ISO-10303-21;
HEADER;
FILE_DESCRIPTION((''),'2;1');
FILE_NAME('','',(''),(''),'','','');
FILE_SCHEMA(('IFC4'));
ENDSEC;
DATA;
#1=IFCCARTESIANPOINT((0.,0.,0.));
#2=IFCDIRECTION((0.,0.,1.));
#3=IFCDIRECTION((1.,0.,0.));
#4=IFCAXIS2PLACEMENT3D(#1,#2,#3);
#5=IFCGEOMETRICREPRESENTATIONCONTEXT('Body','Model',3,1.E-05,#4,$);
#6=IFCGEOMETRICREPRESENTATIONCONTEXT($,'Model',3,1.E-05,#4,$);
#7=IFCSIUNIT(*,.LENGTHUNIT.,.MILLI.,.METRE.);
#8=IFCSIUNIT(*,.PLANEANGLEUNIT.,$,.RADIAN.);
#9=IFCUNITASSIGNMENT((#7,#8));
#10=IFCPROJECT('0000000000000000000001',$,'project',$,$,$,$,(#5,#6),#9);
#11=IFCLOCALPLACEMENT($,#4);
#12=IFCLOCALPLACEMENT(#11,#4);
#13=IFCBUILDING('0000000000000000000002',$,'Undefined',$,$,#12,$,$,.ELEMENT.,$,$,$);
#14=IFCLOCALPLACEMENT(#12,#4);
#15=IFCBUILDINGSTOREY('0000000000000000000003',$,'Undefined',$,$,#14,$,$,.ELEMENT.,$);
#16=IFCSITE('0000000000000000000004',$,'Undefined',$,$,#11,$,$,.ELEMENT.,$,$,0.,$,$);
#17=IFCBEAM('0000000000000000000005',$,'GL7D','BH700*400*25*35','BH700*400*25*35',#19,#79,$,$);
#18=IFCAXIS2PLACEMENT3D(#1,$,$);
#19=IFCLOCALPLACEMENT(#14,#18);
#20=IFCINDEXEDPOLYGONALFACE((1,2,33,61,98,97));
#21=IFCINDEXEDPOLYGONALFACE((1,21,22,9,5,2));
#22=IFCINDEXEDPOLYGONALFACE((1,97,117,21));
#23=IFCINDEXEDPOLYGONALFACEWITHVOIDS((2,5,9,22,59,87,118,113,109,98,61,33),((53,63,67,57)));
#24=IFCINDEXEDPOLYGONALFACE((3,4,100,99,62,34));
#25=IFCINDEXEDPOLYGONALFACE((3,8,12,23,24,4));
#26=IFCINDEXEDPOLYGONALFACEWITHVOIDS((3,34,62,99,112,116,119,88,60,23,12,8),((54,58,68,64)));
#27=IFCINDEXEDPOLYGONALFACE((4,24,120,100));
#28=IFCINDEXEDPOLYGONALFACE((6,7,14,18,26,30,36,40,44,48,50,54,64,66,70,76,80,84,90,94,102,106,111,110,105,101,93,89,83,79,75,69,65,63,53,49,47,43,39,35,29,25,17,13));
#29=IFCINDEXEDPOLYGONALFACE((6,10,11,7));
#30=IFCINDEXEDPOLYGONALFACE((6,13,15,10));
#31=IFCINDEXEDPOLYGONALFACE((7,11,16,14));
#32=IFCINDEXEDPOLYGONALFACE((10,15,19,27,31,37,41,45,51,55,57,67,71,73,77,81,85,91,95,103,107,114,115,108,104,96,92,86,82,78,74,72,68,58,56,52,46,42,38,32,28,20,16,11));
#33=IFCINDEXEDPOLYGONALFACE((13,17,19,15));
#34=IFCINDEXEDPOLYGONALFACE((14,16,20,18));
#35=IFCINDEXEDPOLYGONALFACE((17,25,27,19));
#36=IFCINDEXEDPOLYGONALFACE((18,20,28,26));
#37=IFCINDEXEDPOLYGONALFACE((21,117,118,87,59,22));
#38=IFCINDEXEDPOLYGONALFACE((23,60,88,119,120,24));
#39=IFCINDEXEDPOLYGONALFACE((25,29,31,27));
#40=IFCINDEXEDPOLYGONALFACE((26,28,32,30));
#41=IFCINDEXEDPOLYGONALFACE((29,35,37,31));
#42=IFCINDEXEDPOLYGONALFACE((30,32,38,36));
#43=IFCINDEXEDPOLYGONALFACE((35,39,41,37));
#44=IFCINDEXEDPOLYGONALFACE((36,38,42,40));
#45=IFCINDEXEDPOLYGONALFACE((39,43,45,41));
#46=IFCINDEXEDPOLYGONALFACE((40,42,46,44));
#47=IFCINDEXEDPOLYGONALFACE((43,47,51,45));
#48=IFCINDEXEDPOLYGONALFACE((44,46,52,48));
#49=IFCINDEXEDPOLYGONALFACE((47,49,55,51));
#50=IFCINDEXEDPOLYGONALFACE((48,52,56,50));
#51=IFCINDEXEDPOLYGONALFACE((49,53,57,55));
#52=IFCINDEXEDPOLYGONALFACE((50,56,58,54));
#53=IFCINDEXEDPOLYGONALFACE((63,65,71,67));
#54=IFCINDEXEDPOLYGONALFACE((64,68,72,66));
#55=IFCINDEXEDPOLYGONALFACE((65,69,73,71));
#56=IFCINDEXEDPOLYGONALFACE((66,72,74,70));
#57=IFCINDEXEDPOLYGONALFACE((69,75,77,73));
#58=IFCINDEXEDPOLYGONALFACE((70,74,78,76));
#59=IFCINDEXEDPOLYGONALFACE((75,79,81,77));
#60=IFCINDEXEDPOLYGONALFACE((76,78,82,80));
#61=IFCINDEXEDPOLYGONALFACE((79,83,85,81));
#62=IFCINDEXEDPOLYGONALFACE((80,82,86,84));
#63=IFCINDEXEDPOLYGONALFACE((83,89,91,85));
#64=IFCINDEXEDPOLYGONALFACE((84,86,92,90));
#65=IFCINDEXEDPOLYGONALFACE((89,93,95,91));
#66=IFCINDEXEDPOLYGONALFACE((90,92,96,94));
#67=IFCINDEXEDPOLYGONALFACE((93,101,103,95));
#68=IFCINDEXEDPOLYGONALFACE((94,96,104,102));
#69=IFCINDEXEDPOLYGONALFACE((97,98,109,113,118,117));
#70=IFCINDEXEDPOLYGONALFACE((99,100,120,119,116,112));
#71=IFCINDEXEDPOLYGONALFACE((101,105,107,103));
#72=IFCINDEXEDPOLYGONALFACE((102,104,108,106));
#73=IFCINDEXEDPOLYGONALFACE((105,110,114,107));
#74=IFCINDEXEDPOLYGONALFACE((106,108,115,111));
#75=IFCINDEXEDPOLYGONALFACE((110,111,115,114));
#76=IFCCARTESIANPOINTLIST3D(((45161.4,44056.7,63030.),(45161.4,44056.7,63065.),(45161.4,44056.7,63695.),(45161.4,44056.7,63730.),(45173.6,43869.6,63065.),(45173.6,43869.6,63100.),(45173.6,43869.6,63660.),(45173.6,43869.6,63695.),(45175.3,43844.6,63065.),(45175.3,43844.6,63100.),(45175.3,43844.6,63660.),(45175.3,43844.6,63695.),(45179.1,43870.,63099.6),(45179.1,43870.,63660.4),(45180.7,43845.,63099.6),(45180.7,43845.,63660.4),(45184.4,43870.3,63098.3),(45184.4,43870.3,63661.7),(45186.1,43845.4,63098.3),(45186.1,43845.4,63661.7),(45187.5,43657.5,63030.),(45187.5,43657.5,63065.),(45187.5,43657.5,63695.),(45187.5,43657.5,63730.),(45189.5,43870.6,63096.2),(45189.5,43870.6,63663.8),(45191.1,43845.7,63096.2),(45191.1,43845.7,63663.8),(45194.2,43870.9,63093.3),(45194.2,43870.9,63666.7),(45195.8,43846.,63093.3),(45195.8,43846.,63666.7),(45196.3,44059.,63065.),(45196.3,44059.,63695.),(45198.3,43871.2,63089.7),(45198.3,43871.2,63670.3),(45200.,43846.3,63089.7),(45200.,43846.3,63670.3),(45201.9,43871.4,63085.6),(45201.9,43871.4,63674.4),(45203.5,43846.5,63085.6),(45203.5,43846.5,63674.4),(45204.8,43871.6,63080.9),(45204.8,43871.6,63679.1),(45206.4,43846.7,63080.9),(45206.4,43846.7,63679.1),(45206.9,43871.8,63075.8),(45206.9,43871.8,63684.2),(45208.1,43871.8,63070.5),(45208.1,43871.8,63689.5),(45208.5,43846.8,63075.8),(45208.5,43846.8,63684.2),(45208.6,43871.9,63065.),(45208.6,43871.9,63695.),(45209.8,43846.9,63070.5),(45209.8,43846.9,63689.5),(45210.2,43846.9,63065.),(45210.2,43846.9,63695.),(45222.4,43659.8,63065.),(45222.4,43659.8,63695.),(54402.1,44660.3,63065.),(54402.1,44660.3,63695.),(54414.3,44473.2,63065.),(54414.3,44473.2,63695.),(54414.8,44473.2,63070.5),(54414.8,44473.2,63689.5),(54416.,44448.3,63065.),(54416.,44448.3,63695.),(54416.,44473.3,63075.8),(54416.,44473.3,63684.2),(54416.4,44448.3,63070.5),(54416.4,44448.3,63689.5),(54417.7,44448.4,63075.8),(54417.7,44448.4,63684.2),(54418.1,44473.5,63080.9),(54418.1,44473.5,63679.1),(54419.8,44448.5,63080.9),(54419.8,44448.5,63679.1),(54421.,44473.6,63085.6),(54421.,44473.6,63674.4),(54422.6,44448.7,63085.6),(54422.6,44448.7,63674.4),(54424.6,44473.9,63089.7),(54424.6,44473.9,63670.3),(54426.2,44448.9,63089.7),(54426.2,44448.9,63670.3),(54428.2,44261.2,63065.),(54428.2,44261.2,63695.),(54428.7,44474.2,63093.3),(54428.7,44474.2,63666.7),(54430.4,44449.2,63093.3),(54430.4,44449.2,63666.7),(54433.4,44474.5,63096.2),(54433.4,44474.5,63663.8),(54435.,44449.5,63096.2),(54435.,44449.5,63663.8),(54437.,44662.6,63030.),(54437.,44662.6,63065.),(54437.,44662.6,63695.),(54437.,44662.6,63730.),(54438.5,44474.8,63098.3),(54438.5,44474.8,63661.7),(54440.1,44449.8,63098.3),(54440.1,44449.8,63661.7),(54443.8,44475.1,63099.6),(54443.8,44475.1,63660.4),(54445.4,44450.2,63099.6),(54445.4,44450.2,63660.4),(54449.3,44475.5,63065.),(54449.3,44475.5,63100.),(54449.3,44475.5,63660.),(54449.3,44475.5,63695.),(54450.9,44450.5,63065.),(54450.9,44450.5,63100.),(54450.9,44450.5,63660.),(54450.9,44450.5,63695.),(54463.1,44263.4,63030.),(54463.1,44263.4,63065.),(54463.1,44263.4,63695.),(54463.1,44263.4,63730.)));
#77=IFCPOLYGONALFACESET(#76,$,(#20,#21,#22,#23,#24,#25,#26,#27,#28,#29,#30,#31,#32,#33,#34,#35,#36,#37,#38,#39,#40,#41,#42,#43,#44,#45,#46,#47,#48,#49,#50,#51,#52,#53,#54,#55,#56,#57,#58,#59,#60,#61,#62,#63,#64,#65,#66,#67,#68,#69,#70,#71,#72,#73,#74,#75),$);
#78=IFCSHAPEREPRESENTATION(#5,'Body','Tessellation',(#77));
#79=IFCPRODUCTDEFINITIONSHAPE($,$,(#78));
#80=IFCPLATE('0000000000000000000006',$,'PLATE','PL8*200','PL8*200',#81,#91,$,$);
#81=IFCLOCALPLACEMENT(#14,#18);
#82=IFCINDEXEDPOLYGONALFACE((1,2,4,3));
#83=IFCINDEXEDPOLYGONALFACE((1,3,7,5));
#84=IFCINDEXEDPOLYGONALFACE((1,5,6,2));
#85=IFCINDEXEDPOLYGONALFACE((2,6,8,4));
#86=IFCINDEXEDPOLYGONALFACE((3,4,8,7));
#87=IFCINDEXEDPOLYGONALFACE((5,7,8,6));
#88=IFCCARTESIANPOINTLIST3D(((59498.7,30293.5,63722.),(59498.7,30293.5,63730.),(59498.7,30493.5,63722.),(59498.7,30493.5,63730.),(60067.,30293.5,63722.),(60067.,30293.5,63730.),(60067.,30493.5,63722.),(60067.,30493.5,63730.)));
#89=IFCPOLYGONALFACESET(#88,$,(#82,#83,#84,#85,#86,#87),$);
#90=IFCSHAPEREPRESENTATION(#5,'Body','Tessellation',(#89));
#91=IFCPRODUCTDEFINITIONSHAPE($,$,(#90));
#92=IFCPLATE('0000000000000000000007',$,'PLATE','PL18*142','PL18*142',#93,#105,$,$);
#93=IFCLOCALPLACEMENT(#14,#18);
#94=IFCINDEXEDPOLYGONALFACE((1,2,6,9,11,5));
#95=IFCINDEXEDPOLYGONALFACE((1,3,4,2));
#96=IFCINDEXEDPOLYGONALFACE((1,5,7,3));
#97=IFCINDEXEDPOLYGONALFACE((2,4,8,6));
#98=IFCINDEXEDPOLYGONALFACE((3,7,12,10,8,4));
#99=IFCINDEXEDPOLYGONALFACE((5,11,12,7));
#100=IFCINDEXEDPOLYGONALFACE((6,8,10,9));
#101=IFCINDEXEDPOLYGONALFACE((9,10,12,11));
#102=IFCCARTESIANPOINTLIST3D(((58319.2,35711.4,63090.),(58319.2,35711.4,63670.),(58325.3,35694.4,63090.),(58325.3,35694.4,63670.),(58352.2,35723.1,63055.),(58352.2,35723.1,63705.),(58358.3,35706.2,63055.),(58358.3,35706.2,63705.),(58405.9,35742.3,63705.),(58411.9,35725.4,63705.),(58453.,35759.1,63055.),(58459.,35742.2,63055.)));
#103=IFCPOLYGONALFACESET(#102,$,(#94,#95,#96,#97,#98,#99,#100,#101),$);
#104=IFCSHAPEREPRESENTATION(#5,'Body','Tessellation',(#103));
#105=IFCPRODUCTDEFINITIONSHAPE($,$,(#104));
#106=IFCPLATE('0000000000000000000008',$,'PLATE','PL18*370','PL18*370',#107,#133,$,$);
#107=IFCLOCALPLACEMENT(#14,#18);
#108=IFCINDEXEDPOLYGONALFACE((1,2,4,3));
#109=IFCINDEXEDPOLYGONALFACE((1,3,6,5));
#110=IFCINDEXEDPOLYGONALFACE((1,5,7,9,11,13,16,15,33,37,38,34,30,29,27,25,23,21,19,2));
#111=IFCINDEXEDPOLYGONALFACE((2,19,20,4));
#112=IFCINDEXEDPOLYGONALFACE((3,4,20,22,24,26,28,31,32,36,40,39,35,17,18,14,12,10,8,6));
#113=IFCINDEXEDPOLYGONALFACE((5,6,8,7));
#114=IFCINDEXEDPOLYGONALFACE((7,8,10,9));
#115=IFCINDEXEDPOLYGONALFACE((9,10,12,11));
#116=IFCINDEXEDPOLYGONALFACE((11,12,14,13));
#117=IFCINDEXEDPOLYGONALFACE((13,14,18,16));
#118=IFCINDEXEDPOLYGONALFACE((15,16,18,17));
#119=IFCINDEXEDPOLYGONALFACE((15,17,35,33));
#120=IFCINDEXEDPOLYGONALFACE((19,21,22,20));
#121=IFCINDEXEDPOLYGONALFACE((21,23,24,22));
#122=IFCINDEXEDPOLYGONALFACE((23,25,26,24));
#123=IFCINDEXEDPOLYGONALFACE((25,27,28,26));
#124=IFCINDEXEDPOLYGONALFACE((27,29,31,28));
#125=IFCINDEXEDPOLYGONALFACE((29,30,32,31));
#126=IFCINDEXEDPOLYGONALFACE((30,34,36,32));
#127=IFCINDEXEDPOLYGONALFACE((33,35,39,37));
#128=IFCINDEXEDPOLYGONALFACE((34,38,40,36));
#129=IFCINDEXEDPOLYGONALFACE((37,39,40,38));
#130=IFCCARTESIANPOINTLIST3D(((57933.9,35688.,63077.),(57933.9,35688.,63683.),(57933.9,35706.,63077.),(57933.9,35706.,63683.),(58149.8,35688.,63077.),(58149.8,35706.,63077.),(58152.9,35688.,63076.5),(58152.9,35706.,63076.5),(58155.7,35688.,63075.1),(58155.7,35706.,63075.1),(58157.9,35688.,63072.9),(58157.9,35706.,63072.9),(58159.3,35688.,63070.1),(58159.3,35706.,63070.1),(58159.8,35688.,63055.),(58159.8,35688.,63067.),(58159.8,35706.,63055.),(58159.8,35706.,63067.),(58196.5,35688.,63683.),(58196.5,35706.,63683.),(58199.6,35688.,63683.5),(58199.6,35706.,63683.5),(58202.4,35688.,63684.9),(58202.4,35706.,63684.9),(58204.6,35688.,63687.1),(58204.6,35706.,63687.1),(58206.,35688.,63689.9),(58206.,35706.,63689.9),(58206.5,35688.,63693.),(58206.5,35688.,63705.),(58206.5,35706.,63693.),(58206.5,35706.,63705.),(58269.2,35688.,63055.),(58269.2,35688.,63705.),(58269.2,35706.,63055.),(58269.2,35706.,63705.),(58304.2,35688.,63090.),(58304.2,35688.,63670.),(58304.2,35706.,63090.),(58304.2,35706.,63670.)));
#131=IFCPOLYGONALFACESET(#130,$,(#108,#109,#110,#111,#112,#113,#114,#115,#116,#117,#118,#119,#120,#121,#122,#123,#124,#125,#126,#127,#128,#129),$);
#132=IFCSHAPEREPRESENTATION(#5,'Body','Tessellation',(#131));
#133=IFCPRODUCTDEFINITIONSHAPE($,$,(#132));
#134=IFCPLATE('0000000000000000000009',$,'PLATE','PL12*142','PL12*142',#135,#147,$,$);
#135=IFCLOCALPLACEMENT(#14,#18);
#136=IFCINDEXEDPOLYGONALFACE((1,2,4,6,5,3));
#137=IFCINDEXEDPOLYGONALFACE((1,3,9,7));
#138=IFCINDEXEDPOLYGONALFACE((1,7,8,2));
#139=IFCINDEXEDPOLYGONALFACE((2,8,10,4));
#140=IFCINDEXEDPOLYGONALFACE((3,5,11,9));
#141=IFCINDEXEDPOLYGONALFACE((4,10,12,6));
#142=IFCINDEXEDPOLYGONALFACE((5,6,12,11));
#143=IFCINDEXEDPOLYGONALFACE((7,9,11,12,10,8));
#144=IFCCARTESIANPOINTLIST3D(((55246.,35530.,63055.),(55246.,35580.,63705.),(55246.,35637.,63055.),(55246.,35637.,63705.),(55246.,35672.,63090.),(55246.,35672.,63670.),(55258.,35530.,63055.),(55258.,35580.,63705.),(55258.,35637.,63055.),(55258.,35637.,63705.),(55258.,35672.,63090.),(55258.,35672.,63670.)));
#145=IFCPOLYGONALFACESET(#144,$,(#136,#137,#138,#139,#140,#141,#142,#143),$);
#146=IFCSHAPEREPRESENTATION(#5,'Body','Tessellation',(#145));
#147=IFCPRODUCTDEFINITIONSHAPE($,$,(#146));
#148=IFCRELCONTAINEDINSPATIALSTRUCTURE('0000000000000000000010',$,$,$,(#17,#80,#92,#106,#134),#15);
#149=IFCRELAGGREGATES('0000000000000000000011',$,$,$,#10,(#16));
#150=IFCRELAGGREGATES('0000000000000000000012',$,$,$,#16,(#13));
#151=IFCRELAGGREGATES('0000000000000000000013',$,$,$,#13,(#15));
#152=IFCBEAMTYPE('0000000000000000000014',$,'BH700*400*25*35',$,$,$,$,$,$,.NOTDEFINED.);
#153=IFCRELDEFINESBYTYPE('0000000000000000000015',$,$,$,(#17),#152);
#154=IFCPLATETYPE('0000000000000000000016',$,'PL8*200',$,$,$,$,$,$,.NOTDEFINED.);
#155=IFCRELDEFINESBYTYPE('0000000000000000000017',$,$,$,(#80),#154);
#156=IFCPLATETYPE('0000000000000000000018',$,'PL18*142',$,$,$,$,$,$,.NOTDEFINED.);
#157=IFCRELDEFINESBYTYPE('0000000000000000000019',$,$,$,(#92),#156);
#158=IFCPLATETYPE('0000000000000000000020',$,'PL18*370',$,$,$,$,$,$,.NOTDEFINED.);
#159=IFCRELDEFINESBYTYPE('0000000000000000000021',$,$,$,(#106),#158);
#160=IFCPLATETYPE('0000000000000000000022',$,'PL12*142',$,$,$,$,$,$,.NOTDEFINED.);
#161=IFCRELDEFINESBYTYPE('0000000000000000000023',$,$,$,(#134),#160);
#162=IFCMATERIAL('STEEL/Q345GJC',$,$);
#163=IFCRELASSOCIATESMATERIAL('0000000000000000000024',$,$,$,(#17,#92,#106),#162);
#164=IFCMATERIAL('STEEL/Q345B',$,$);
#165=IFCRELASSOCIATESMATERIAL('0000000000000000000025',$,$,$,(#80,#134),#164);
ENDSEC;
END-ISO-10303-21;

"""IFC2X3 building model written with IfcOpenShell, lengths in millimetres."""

from ifc_helpers import new_model, si_unit, frame, origin_with_axes, origin_2d_with_axis, place, context, project, spatial, polyline, i_section, outline, extrude, material, type_object, element, save


model = new_model("IFC2X3")

# Units and contexts
model_context_1 = context("Model", 3, precision=1e-05, world=origin_with_axes(), identifier="Body")
model_context_2 = context("Model", 3, precision=1e-05, world=origin_with_axes())
ifc_project = project(units=[si_unit("LENGTHUNIT", "METRE", prefix="MILLI"), si_unit("PLANEANGLEUNIT", "RADIAN")], contexts=[model_context_1, model_context_2])

# Site, building, storey
site_placement = place(None, origin_with_axes())
site = spatial("IfcSite", under=ifc_project, at=site_placement, Name="Undefined", CompositionType="ELEMENT", RefElevation=0.0)
building_placement = place(site_placement, origin_with_axes())
building = spatial("IfcBuilding", under=site, at=building_placement, Name="Undefined", CompositionType="ELEMENT")
storey_placement = place(building_placement, origin_with_axes())
storey = spatial("IfcBuildingStorey", under=building, at=storey_placement, Name="Undefined", CompositionType="ELEMENT")

# Shared definitions
ifc_material_1 = material(Name="STEEL/Q345B")
ifc_material_2 = material(Name="STEEL/Q345GJC")

# Beam, openings
beam_type_1 = type_object("IfcBeamType", Name="BH700*400*25*35", PredefinedType="NOTDEFINED")
beam_1_placement = place(storey_placement, frame((55367.7, 44523.0, 63380.0), z_axis=(0.0, 0.0, 1.0), x_axis=(-0.997873, -0.065183, 0.0)))
beam_1 = element("IfcBeam", 1, at=beam_1_placement, inside=storey, type_object=beam_type_1, material=ifc_material_2, Name="GL7D", Description="BH700*400*25*35", ObjectType="BH700*400*25*35", context=model_context_1, shape_type="SweptSolid", body=[
    extrude(i_section(OverallWidth=400.0, OverallDepth=700.0, WebThickness=25.0, FlangeThickness=35.0, at=origin_2d_with_axis()), frame((10215.0, 0.0, 0.0), z_axis=(-1.0, 0.0, 0.0), x_axis=(0.0, -1.0, 0.0)), (0.0, 0.0, 1.0), 9295.4),
])
opening_1_placement = place(storey_placement, frame((55367.7, 44523.0, 63380.0), z_axis=(0.0, 0.0, 1.0), x_axis=(-0.997873, -0.065183, 0.0)))
element("IfcOpeningElement", 2, at=opening_1_placement, cuts=beam_1, ObjectType="Recess", context=model_context_1, shape_type="SweptSolid", body=[
    extrude(outline(polyline([(0.0, 0.0), (37.0, 0.0), (37.0, 35.0), (35.0, 35.0), (29.5, 34.6), (24.2, 33.3), (19.1, 31.2), (14.4, 28.3), (10.3, 24.7), (6.7, 20.6), (3.8, 15.9), (1.7, 10.8), (0.4, 5.5), (0.0, 0.0), (0.0, 0.0)])), frame((10180.0, -200.0, 315.0), z_axis=(0.0, 1.0, 0.0), x_axis=(1.0, 0.0, 0.0)), (0.0, 0.0, 1.0), 400.0),
])
opening_2_placement = place(storey_placement, frame((55367.7, 44523.0, 63380.0), z_axis=(0.0, 0.0, 1.0), x_axis=(-0.997873, -0.065183, 0.0)))
element("IfcOpeningElement", 3, at=opening_2_placement, cuts=beam_1, ObjectType="Recess", context=model_context_1, shape_type="SweptSolid", body=[
    extrude(outline(polyline([(0.0, 0.0), (37.0, 0.0), (36.6, 5.5), (35.3, 10.8), (33.2, 15.9), (30.3, 20.6), (26.7, 24.7), (22.6, 28.3), (17.9, 31.2), (12.8, 33.3), (7.5, 34.6), (2.0, 35.0), (0.0, 35.0), (0.0, 0.0)])), frame((10217.0, -200.0, -315.0), z_axis=(0.0, 1.0, 0.0), x_axis=(-1.0, 0.0, 0.0)), (0.0, 0.0, 1.0), 400.0),
])
opening_3_placement = place(storey_placement, frame((55367.7, 44523.0, 63380.0), z_axis=(0.0, 0.0, 1.0), x_axis=(-0.997873, -0.065183, 0.0)))
element("IfcOpeningElement", 4, at=opening_3_placement, cuts=beam_1, ObjectType="Recess", context=model_context_1, shape_type="SweptSolid", body=[
    extrude(outline(polyline([(0.0, 0.0), (37.0, 0.0), (37.0, 35.0), (35.0, 35.0), (29.5, 34.6), (24.2, 33.3), (19.1, 31.2), (14.4, 28.3), (10.3, 24.7), (6.7, 20.6), (3.8, 15.9), (1.7, 10.8), (0.4, 5.5), (0.0, 0.0), (0.0, 0.0)])), frame((954.6, 200.0, 315.0), z_axis=(0.0, -1.0, 0.0), x_axis=(-1.0, 0.0, 0.0)), (0.0, 0.0, 1.0), 400.0),
])
opening_4_placement = place(storey_placement, frame((55367.7, 44523.0, 63380.0), z_axis=(0.0, 0.0, 1.0), x_axis=(-0.997873, -0.065183, 0.0)))
element("IfcOpeningElement", 5, at=opening_4_placement, cuts=beam_1, ObjectType="Recess", context=model_context_1, shape_type="SweptSolid", body=[
    extrude(outline(polyline([(0.0, 0.0), (37.0, 0.0), (36.6, 5.5), (35.3, 10.8), (33.2, 15.9), (30.3, 20.6), (26.7, 24.7), (22.6, 28.3), (17.9, 31.2), (12.8, 33.3), (7.5, 34.6), (2.0, 35.0), (0.0, 35.0), (0.0, 0.0)])), frame((917.6, 200.0, -315.0), z_axis=(0.0, -1.0, 0.0), x_axis=(1.0, 0.0, 0.0)), (0.0, 0.0, 1.0), 400.0),
])
opening_5_placement = place(storey_placement, frame((55367.7, 44523.0, 63380.0), z_axis=(0.0, 0.0, 1.0), x_axis=(-0.997873, -0.065183, 0.0)))
element("IfcOpeningElement", 6, at=opening_5_placement, cuts=beam_1, ObjectType="Recess", context=model_context_1, shape_type="SweptSolid", body=[
    extrude(outline(polyline([(0.0, 0.0), (37.0, 0.0), (37.0, 35.0), (35.0, 35.0), (29.5, 34.6), (24.2, 33.3), (19.1, 31.2), (14.4, 28.3), (10.3, 24.7), (6.7, 20.6), (3.8, 15.9), (1.7, 10.8), (0.4, 5.5), (0.0, 0.0), (0.0, 0.0)])), frame((954.6, 200.0, 315.0), z_axis=(0.0, -1.0, 0.0), x_axis=(-1.0, 0.0, 0.0)), (0.0, 0.0, 1.0), 400.0),
])
opening_6_placement = place(storey_placement, frame((55367.7, 44523.0, 63380.0), z_axis=(0.0, 0.0, 1.0), x_axis=(-0.997873, -0.065183, 0.0)))
element("IfcOpeningElement", 7, at=opening_6_placement, cuts=beam_1, ObjectType="Recess", context=model_context_1, shape_type="SweptSolid", body=[
    extrude(outline(polyline([(0.0, 0.0), (37.0, 0.0), (36.6, 5.5), (35.3, 10.8), (33.2, 15.9), (30.3, 20.6), (26.7, 24.7), (22.6, 28.3), (17.9, 31.2), (12.8, 33.3), (7.5, 34.6), (2.0, 35.0), (0.0, 35.0), (0.0, 0.0)])), frame((917.6, 200.0, -315.0), z_axis=(0.0, -1.0, 0.0), x_axis=(1.0, 0.0, 0.0)), (0.0, 0.0, 1.0), 400.0),
])

# Plates
plate_type_1 = type_object("IfcPlateType", Name="PL8*200", PredefinedType="NOTDEFINED")
plate_1_placement = place(storey_placement, frame((60067.0, 30493.5, 63726.0), z_axis=(0.0, 0.0, 1.0), x_axis=(-1.0, 0.0, 0.0)))
element("IfcPlate", 8, at=plate_1_placement, inside=storey, type_object=plate_type_1, material=ifc_material_1, Name="PLATE", Description="PL8*200", ObjectType="PL8*200", context=model_context_1, shape_type="SweptSolid", body=[
    extrude(outline(polyline([(0.0, 0.0), (568.3, 0.0), (568.3, 200.0), (0.0, 200.0), (0.0, 0.0)])), frame((0.0, 0.0, -4.0), z_axis=(0.0, 0.0, 1.0), x_axis=(1.0, 0.0, 0.0)), (0.0, 0.0, 1.0), 8.0),
])
plate_type_2 = type_object("IfcPlateType", Name="PL18*142", PredefinedType="NOTDEFINED")
plate_2_placement = place(storey_placement, frame((58322.3, 35702.9, 63705.0), z_axis=(-0.336214, 0.941786, 0.0), x_axis=(0.941786, 0.336214, 0.0)))
element("IfcPlate", 9, at=plate_2_placement, inside=storey, type_object=plate_type_2, material=ifc_material_2, Name="PLATE", Description="PL18*142", ObjectType="PL18*142", context=model_context_1, shape_type="SweptSolid", body=[
    extrude(outline(polyline([(0.0, 35.0), (35.0, 0.0), (92.0, 0.0), (142.0, 650.0), (35.0, 650.0), (0.0, 615.0), (0.0, 35.0)])), frame((0.0, 0.0, -9.0), z_axis=(0.0, 0.0, 1.0), x_axis=(1.0, 0.0, 0.0)), (0.0, 0.0, 1.0), 18.0),
])
plate_type_3 = type_object("IfcPlateType", Name="PL18*370", PredefinedType="NOTDEFINED")
plate_3_placement = place(storey_placement, frame((58206.5, 35697.0, 63705.0), z_axis=(0.0, 1.0, 0.0), x_axis=(1.0, 0.0, 0.0)))
element("IfcPlate", 10, at=plate_3_placement, inside=storey, type_object=plate_type_3, material=ifc_material_2, Name="PLATE", Description="PL18*370", ObjectType="PL18*370", context=model_context_1, shape_type="SweptSolid", body=[
    extrude(outline(polyline([(0.0, 0.0), (62.7, 0.0), (97.7, 35.0), (97.7, 615.0), (62.7, 650.0), (-46.7, 650.0), (-46.7, 638.0), (-47.2, 634.9), (-48.6, 632.1), (-50.8, 629.9), (-53.6, 628.5), (-56.7, 628.0), (-272.6, 628.0), (-272.6, 22.0), (-10.0, 22.0), (-6.9, 21.5), (-4.1, 20.1), (-1.9, 17.9), (-0.5, 15.1), (0.0, 12.0), (0.0, 0.0)])), frame((0.0, 0.0, -9.0), z_axis=(0.0, 0.0, 1.0), x_axis=(1.0, 0.0, 0.0)), (0.0, 0.0, 1.0), 18.0),
])
plate_type_4 = type_object("IfcPlateType", Name="PL12*142", PredefinedType="NOTDEFINED")
for number, where, z_axis, x_axis, name in (
    (11, (55252.0, 35530.0, 63055.0), (1.0, 0.0, 0.0), (0.0, 1.0, 0.0), "PLATE"),
):
    element("IfcPlate", number, at=place(storey_placement, frame(where, z_axis=z_axis, x_axis=x_axis)), inside=storey, type_object=plate_type_4, material=ifc_material_1, Name=name, Description="PL12*142", ObjectType="PL12*142", context=model_context_1, shape_type="SweptSolid", body=[
        extrude(outline(polyline([(0.0, 0.0), (107.0, 0.0), (142.0, 35.0), (142.0, 615.0), (107.0, 650.0), (50.0, 650.0), (0.0, 0.0)])), frame((0.0, 0.0, -6.0), z_axis=(0.0, 0.0, 1.0), x_axis=(1.0, 0.0, 0.0)), (0.0, 0.0, 1.0), 12.0),
    ])

save(model, "model.ifc")
